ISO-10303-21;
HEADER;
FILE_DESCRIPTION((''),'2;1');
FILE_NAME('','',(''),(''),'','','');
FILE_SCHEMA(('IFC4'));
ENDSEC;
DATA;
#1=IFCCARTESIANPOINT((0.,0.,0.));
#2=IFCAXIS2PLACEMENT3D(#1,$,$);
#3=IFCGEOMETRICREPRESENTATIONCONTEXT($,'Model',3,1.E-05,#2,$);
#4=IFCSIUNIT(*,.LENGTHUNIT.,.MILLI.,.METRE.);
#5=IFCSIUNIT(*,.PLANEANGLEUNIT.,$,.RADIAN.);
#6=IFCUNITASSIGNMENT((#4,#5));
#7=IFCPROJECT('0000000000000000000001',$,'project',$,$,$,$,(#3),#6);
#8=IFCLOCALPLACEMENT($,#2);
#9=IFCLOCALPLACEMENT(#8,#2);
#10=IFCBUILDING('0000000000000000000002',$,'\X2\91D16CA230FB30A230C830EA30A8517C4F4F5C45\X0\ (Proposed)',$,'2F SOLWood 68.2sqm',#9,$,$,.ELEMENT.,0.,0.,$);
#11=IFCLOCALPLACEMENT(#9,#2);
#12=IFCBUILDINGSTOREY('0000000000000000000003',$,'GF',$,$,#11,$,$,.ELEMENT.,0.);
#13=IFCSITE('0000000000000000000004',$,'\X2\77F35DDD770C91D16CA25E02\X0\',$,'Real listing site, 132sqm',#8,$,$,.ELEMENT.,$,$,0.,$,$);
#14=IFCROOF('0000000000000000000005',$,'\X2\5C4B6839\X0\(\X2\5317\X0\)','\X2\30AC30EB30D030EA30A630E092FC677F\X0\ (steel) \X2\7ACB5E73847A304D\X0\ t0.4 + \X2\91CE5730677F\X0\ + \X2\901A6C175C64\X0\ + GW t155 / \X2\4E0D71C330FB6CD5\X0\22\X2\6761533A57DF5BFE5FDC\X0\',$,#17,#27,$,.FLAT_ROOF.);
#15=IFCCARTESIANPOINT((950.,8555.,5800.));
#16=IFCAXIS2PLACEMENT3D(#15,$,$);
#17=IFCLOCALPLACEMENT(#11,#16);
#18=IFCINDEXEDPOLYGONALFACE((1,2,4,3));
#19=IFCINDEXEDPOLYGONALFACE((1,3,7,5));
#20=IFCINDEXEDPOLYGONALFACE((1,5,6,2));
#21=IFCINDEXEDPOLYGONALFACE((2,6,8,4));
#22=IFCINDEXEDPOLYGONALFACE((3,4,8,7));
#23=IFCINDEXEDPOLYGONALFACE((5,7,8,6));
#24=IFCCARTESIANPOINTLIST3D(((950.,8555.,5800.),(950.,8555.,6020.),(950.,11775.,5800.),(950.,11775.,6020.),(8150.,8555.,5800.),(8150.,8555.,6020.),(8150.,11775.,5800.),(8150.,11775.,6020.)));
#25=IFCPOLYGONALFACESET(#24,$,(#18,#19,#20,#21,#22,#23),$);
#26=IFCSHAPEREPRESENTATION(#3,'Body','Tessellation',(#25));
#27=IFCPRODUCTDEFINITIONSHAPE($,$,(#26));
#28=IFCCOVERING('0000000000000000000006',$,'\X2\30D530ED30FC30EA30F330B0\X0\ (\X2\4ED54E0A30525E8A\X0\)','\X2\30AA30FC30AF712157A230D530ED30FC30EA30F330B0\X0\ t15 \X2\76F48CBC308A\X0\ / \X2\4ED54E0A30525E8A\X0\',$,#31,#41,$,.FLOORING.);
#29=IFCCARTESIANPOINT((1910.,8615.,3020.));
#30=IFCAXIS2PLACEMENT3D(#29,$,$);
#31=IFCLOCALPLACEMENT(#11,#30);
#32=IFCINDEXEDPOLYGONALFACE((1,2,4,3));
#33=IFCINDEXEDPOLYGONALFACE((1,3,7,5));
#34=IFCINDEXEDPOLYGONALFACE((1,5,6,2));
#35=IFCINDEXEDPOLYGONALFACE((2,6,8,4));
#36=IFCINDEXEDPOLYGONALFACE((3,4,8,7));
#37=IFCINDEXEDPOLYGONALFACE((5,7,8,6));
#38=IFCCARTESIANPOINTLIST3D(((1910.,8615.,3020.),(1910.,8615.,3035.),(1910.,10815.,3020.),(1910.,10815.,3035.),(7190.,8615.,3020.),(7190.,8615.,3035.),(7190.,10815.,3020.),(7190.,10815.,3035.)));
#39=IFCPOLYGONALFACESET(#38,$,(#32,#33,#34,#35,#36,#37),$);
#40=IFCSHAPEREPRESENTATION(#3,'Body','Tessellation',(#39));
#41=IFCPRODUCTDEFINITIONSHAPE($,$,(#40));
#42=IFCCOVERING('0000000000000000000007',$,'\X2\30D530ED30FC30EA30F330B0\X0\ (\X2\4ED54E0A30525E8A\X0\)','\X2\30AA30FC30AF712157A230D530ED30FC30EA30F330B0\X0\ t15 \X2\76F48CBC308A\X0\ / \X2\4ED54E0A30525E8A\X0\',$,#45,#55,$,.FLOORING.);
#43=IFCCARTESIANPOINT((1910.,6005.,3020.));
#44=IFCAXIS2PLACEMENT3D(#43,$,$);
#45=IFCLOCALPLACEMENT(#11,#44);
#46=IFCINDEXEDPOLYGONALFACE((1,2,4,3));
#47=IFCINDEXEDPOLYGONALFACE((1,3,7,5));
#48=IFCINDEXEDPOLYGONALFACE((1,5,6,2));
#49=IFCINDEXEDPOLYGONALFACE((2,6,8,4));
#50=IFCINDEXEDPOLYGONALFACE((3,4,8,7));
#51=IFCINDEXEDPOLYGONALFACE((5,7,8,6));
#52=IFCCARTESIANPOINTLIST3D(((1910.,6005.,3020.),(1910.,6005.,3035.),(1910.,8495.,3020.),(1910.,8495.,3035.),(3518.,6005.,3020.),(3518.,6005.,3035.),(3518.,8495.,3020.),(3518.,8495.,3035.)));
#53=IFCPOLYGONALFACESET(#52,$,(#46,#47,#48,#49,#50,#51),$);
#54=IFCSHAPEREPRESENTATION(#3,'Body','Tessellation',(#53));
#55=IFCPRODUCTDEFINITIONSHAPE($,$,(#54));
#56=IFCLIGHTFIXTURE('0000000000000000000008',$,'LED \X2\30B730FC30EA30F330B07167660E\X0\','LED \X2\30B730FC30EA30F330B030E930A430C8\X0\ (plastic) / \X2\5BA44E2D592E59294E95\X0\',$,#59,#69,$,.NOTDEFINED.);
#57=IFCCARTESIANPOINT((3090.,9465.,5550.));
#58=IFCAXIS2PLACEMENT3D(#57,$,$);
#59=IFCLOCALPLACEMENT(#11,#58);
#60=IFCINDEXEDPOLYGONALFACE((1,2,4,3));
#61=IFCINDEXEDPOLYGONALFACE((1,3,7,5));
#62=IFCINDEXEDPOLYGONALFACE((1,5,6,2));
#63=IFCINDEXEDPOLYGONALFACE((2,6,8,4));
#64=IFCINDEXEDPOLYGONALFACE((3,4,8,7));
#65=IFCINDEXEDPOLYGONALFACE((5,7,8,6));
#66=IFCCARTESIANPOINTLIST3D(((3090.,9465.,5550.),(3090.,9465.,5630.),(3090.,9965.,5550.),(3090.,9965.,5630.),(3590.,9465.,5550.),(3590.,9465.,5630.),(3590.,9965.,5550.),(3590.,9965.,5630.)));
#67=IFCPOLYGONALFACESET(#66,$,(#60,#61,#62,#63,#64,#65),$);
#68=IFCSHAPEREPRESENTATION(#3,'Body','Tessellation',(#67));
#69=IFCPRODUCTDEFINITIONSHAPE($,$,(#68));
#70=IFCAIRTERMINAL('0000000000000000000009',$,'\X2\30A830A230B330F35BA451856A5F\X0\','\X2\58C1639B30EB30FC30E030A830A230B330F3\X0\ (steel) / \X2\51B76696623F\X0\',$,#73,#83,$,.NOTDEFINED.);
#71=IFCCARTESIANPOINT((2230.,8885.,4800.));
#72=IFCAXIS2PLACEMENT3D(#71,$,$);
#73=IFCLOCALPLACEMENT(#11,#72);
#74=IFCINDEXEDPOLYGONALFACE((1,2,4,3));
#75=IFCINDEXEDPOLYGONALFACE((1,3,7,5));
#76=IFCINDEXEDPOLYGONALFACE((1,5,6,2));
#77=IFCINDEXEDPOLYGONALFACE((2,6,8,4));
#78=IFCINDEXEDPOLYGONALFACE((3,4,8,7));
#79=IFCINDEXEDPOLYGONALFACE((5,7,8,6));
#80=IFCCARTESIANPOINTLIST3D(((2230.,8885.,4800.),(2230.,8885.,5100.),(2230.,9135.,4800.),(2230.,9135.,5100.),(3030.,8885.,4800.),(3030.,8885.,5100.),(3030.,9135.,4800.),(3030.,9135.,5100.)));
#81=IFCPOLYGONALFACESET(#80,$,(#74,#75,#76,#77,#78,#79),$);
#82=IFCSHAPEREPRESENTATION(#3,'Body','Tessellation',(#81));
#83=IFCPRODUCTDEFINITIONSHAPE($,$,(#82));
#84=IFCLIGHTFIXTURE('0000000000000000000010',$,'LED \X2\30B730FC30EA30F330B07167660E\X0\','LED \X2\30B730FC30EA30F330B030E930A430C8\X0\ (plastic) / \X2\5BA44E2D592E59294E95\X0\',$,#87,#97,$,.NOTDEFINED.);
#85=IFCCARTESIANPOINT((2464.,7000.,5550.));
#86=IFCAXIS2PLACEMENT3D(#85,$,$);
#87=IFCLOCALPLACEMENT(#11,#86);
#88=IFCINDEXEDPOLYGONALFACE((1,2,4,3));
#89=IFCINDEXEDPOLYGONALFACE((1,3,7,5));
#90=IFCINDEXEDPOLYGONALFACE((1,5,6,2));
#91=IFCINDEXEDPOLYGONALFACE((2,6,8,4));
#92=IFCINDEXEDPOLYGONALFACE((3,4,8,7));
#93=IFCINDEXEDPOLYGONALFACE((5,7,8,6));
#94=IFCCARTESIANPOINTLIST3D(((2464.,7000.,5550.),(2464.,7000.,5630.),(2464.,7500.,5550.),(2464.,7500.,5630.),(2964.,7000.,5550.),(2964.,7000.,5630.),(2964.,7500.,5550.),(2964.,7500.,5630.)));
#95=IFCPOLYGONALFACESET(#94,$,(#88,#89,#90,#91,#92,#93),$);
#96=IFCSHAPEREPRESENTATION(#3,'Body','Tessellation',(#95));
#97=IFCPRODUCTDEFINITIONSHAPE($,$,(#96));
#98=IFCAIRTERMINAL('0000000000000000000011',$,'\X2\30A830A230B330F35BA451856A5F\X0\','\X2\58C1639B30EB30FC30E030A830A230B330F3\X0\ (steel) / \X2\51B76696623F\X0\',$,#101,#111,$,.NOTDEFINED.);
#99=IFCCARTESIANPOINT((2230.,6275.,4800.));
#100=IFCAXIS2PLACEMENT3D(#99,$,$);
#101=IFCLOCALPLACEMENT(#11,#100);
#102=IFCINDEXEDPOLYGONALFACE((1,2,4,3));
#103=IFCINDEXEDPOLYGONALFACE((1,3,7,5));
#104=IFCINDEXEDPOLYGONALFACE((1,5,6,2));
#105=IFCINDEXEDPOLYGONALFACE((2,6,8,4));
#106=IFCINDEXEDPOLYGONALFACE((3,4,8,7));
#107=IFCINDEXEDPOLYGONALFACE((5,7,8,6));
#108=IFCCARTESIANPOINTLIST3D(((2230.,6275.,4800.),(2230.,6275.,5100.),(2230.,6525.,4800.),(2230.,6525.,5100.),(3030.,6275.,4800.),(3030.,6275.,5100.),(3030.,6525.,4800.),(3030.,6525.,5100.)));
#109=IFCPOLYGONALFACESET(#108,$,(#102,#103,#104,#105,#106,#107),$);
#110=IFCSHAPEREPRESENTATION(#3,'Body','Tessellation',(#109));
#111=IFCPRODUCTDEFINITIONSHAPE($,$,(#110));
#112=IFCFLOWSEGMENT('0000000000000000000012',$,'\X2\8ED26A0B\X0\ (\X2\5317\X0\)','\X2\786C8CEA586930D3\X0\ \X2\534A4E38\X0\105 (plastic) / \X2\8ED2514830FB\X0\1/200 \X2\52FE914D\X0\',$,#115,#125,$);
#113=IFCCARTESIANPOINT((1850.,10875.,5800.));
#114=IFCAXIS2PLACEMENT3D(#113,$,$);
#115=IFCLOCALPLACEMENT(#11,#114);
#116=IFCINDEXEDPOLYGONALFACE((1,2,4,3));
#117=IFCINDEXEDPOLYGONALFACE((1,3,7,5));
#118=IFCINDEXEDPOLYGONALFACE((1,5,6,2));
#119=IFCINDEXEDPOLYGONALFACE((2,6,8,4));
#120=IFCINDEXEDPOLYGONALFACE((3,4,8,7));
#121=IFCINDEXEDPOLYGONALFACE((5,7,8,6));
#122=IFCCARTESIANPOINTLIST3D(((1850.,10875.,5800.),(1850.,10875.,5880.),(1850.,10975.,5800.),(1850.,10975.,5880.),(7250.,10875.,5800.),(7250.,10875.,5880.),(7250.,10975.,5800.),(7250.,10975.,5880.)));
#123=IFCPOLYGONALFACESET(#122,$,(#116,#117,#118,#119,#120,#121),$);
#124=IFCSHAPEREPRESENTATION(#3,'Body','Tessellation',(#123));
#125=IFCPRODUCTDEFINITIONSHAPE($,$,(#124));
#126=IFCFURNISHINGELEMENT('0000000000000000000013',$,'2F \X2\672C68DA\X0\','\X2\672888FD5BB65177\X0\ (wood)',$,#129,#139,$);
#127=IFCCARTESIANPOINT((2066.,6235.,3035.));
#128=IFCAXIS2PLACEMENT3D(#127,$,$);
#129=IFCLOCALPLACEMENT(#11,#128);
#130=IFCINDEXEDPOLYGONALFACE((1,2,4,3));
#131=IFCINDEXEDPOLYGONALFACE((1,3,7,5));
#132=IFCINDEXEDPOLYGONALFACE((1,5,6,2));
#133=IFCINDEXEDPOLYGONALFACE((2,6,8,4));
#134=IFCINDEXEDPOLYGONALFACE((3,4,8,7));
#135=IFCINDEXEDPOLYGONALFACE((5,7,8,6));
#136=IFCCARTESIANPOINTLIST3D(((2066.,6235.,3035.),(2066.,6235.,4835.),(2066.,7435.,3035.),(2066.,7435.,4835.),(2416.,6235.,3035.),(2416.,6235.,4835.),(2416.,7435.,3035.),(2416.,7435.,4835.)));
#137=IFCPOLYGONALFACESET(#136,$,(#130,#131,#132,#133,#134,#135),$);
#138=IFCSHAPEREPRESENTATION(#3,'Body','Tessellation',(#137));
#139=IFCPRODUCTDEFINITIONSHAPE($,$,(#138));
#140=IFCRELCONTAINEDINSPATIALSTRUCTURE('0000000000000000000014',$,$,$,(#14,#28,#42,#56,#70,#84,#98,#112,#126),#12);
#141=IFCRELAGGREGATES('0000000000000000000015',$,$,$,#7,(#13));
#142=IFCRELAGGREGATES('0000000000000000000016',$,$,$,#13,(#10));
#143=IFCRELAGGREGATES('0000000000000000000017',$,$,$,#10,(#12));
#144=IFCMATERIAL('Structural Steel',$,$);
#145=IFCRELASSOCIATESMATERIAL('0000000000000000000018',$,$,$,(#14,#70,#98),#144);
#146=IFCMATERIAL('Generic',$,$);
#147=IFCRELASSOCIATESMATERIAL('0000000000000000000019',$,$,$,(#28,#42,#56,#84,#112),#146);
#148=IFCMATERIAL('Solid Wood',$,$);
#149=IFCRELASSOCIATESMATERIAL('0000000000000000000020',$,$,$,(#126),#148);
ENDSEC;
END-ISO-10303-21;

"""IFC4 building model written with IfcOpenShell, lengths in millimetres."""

from ifc_helpers import new_model, si_unit, frame, frame_2d, origin, place, context, project, spatial, rectangle, extrude, material, element, save


model = new_model("IFC4")

# Units and contexts
model_context = context("Model", 3, precision=1e-05, world=origin())
ifc_project = project(units=[si_unit("LENGTHUNIT", "METRE", prefix="MILLI"), si_unit("PLANEANGLEUNIT", "RADIAN")], contexts=[model_context])

# Site, building, storey
site_placement = place(None, origin())
site = spatial("IfcSite", under=ifc_project, at=site_placement, Name="石川県金沢市", ObjectType="Real listing site, 132sqm", CompositionType="ELEMENT", RefElevation=0.0)
building_placement = place(site_placement, origin())
building = spatial("IfcBuilding", under=site, at=building_placement, Name="金沢・アトリエ兼住居 (Proposed)", ObjectType="2F SOLWood 68.2sqm", CompositionType="ELEMENT", ElevationOfRefHeight=0.0, ElevationOfTerrain=0.0)
storey_placement = place(building_placement, origin())
storey = spatial("IfcBuildingStorey", under=building, at=storey_placement, Name="GF", CompositionType="ELEMENT", Elevation=0.0)

# Shared definitions
ifc_material_1 = material(Name="Solid Wood")

# Roof
ifc_material_2 = material(Name="Structural Steel")
for number, where, name in (
    (1, (950.0, 8555.0, 5800.0), "屋根(北)"),
):
    element("IfcRoof", number, at=place(storey_placement, frame(where)), inside=storey, material=ifc_material_2, Name=name, Description="ガルバリウム鋼板 (steel) 立平葺き t0.4 + 野地板 + 通気層 + GW t155 / 不燃・法22条区域対応", PredefinedType="FLAT_ROOF", context=model_context, shape_type="SweptSolid", body=[
        extrude(rectangle(XDim=7200.0, YDim=3220.0, at=frame_2d((3600.0, 1610.0))), frame((950.0, 8555.0, 5800.0)), (0.0, 0.0, 1.0), 220.0),
    ])

# Coverings
ifc_material_3 = material(Name="Generic")
covering_1_placement = place(storey_placement, frame((1910.0, 8615.0, 3020.0)))
element("IfcCovering", 2, at=covering_1_placement, inside=storey, material=ifc_material_3, Name="フローリング (仕上げ床)", Description="オーク無垢フローリング t15 直貼り / 仕上げ床", PredefinedType="FLOORING", context=model_context, shape_type="SweptSolid", body=[
    extrude(rectangle(XDim=5280.0, YDim=2200.0, at=frame_2d((2640.0, 1100.0))), frame((1910.0, 8615.0, 3020.0)), (0.0, 0.0, 1.0), 15.0),
])
covering_2_placement = place(storey_placement, frame((1910.0, 6005.0, 3020.0)))
element("IfcCovering", 3, at=covering_2_placement, inside=storey, material=ifc_material_3, Name="フローリング (仕上げ床)", Description="オーク無垢フローリング t15 直貼り / 仕上げ床", PredefinedType="FLOORING", context=model_context, shape_type="SweptSolid", body=[
    extrude(rectangle(XDim=1608.0, YDim=2490.0, at=frame_2d((804.0, 1245.0))), frame((1910.0, 6005.0, 3020.0)), (0.0, 0.0, 1.0), 15.0),
])

# Light fixture
light_fixture_1_placement = place(storey_placement, frame((3090.0, 9465.0, 5550.0)))
element("IfcLightFixture", 4, at=light_fixture_1_placement, inside=storey, material=ifc_material_3, Name="LED シーリング照明", Description="LED シーリングライト (plastic) / 室中央天井", PredefinedType="NOTDEFINED", context=model_context, shape_type="SweptSolid", body=[
    extrude(rectangle(XDim=500.0, YDim=500.0, at=frame_2d((250.0, 250.0))), frame((3090.0, 9465.0, 5550.0)), (0.0, 0.0, 1.0), 80.0),
])

# Air terminal
air_terminal_1_placement = place(storey_placement, frame((2230.0, 8885.0, 4800.0)))
element("IfcAirTerminal", 5, at=air_terminal_1_placement, inside=storey, material=ifc_material_2, Name="エアコン室内機", Description="壁掛ルームエアコン (steel) / 冷暖房", PredefinedType="NOTDEFINED", context=model_context, shape_type="SweptSolid", body=[
    extrude(rectangle(XDim=800.0, YDim=250.0, at=frame_2d((400.0, 125.0))), frame((2230.0, 8885.0, 4800.0)), (0.0, 0.0, 1.0), 300.0),
])

# Light fixture
light_fixture_2_placement = place(storey_placement, frame((2464.0, 7000.0, 5550.0)))
element("IfcLightFixture", 6, at=light_fixture_2_placement, inside=storey, material=ifc_material_3, Name="LED シーリング照明", Description="LED シーリングライト (plastic) / 室中央天井", PredefinedType="NOTDEFINED", context=model_context, shape_type="SweptSolid", body=[
    extrude(rectangle(XDim=500.0, YDim=500.0, at=frame_2d((250.0, 250.0))), frame((2464.0, 7000.0, 5550.0)), (0.0, 0.0, 1.0), 80.0),
])

# Air terminal
air_terminal_2_placement = place(storey_placement, frame((2230.0, 6275.0, 4800.0)))
element("IfcAirTerminal", 7, at=air_terminal_2_placement, inside=storey, material=ifc_material_2, Name="エアコン室内機", Description="壁掛ルームエアコン (steel) / 冷暖房", PredefinedType="NOTDEFINED", context=model_context, shape_type="SweptSolid", body=[
    extrude(rectangle(XDim=800.0, YDim=250.0, at=frame_2d((400.0, 125.0))), frame((2230.0, 6275.0, 4800.0)), (0.0, 0.0, 1.0), 300.0),
])

# Flow segment
flow_segment_placement = place(storey_placement, frame((1850.0, 10875.0, 5800.0)))
element("IfcFlowSegment", 8, at=flow_segment_placement, inside=storey, material=ifc_material_3, Name="軒樋 (北)", Description="硬質塩ビ 半丸105 (plastic) / 軒先・1/200 勾配", context=model_context, shape_type="SweptSolid", body=[
    extrude(rectangle(XDim=5400.0, YDim=100.0, at=frame_2d((2700.0, 50.0))), frame((1850.0, 10875.0, 5800.0)), (0.0, 0.0, 1.0), 80.0),
])

# Furnishing element
furnishing_placement = place(storey_placement, frame((2066.0, 6235.0, 3035.0)))
element("IfcFurnishingElement", 9, at=furnishing_placement, inside=storey, material=ifc_material_1, Name="2F 本棚", Description="木製家具 (wood)", context=model_context, shape_type="SweptSolid", body=[
    extrude(rectangle(XDim=350.0, YDim=1200.0, at=frame_2d((175.0, 600.0))), frame((2066.0, 6235.0, 3035.0)), (0.0, 0.0, 1.0), 1800.0),
])

save(model, "model.ifc")
